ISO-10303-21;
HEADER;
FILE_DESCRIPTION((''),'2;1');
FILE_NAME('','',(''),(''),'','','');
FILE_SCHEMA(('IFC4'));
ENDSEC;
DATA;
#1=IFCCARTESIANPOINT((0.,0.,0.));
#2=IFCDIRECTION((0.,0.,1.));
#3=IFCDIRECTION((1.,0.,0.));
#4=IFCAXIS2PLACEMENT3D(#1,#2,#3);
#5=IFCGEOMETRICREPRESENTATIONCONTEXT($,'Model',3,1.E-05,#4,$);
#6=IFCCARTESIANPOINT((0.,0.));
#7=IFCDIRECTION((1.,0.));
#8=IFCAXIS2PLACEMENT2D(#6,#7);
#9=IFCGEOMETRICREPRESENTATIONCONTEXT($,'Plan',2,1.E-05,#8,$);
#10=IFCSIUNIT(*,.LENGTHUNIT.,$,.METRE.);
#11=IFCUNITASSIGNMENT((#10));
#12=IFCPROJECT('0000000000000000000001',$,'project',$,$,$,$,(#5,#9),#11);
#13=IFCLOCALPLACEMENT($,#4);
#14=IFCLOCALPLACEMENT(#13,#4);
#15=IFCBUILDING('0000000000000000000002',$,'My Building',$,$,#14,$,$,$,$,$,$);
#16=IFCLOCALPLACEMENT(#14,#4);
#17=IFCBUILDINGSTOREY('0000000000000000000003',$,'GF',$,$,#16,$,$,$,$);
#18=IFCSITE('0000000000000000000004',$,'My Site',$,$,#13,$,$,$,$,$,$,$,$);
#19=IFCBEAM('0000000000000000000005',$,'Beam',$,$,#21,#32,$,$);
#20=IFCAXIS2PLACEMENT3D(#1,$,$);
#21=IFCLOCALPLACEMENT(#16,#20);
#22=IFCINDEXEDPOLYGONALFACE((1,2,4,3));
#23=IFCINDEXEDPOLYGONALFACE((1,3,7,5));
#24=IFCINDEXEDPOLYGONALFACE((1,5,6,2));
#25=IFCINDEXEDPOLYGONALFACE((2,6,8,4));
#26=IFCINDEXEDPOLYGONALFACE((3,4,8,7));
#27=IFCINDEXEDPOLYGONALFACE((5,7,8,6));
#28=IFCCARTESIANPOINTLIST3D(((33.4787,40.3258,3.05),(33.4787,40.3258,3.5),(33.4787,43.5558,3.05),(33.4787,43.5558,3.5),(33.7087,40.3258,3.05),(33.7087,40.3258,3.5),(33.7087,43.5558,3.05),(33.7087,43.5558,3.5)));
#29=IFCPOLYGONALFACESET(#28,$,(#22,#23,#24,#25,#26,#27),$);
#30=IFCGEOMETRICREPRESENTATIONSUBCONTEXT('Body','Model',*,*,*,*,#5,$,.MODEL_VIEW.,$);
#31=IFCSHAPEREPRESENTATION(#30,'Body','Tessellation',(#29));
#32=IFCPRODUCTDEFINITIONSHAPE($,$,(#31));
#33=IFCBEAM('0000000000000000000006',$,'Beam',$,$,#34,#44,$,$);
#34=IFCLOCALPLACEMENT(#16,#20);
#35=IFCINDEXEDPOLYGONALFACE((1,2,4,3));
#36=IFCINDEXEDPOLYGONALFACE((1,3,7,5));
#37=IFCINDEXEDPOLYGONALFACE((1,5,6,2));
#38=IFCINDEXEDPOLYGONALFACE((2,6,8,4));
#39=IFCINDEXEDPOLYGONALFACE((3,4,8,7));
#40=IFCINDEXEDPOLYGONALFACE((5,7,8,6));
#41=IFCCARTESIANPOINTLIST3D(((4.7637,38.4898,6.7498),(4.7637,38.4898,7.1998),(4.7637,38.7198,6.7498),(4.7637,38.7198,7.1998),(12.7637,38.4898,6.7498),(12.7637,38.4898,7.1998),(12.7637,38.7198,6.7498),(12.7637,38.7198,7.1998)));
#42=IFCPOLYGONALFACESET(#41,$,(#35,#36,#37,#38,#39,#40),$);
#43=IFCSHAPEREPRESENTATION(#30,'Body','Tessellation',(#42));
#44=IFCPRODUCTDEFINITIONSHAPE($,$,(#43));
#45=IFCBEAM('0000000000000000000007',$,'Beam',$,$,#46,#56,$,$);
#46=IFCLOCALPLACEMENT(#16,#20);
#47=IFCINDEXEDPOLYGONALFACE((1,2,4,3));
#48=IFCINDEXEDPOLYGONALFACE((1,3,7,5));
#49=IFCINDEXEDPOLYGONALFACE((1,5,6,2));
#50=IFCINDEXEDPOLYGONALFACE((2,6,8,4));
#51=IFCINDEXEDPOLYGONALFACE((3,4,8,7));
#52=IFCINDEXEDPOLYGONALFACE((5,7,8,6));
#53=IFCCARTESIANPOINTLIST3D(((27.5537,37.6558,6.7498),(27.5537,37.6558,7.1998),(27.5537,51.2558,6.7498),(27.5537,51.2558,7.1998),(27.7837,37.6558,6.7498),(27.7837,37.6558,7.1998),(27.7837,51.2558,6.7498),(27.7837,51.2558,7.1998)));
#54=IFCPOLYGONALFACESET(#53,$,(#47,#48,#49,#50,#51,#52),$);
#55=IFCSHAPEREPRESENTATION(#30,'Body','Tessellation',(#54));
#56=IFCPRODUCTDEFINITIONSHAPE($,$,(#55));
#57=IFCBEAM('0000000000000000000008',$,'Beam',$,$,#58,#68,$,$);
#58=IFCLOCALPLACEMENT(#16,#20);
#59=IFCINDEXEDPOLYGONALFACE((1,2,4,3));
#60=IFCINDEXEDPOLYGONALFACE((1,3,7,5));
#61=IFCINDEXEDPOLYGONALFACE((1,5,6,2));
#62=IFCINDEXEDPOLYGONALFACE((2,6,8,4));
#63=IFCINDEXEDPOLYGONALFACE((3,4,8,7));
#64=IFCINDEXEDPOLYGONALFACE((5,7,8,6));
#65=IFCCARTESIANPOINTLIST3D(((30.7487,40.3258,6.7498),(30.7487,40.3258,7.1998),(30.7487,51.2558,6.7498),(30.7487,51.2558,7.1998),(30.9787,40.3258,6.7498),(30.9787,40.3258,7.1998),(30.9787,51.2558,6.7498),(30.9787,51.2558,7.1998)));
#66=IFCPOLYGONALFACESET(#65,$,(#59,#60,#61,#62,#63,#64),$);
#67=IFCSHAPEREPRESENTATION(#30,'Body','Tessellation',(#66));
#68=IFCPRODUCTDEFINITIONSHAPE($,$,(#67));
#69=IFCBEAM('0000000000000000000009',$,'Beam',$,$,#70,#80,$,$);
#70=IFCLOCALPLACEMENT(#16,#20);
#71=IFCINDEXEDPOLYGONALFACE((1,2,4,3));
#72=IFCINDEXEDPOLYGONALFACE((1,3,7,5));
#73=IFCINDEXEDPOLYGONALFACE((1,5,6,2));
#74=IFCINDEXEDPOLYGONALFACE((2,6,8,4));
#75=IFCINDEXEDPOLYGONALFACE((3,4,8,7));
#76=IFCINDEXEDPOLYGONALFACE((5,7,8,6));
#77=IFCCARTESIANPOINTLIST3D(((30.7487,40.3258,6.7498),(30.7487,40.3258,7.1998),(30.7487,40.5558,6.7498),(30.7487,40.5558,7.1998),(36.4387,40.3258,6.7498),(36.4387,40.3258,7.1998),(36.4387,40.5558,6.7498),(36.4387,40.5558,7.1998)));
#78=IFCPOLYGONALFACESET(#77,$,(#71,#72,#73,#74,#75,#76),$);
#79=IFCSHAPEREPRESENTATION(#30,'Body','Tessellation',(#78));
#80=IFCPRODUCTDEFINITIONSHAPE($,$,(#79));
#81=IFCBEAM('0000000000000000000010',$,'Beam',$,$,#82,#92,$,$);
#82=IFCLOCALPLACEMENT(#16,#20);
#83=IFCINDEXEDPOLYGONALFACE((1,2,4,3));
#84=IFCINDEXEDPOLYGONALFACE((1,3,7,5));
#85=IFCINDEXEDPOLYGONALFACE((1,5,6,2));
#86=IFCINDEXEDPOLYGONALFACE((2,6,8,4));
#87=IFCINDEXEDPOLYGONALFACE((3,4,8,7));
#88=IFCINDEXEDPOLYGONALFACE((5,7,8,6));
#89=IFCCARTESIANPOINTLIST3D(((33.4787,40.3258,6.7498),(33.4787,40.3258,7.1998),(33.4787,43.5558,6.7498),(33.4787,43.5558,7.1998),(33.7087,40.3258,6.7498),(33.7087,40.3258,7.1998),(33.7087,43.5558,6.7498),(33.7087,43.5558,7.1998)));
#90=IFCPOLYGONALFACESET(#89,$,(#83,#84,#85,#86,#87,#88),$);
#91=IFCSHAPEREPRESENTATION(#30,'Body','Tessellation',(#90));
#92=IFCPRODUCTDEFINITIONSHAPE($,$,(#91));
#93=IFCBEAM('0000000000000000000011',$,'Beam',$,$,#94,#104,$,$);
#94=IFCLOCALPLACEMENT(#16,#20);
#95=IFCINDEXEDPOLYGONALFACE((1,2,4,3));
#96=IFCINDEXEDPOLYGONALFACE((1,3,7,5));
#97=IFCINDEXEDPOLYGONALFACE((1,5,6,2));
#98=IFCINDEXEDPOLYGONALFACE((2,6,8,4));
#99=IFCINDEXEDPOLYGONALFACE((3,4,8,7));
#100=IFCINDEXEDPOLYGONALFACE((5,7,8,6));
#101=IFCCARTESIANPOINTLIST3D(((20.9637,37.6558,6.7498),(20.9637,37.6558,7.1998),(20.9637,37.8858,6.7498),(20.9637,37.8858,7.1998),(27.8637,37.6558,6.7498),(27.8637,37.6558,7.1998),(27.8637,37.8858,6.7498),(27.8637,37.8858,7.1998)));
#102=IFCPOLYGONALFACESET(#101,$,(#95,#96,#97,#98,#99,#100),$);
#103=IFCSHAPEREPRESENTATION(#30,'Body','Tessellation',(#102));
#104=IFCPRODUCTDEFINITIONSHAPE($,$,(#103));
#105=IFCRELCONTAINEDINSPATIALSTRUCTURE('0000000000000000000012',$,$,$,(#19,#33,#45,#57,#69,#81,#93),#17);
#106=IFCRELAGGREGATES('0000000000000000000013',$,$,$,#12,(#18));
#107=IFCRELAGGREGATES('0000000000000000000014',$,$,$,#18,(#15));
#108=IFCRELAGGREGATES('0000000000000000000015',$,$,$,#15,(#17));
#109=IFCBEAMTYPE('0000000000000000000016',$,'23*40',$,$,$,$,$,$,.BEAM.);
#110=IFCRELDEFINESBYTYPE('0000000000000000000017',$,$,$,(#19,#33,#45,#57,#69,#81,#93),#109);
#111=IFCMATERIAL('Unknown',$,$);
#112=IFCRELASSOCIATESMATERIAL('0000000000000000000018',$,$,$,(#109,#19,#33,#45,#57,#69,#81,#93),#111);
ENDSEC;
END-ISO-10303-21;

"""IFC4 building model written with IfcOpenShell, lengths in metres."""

from ifc_helpers import new_model, si_unit, frame, origin_with_axes, origin_2d_with_axis, place, context, subcontext, project, spatial, rectangle, extrude, material, material_profile, profile_set, profile_usage, type_object, element, save


model = new_model("IFC4")

# Units and contexts
model_context = context("Model", 3, precision=1e-05, world=origin_with_axes())
plan_context = context("Plan", 2, precision=1e-05, world=origin_2d_with_axis())
body_context = subcontext(model_context, "Body", "Model", "MODEL_VIEW")
ifc_project = project(units=[si_unit("LENGTHUNIT", "METRE")], contexts=[model_context, plan_context])

# Site, building, storey
site_placement = place(None, origin_with_axes())
site = spatial("IfcSite", under=ifc_project, at=site_placement, Name="My Site")
building_placement = place(site_placement, origin_with_axes())
building = spatial("IfcBuilding", under=site, at=building_placement, Name="My Building")
storey_placement = place(building_placement, origin_with_axes())
storey = spatial("IfcBuildingStorey", under=building, at=storey_placement, Name="GF")

# Shared definitions
ifc_material = material(Name="Unknown")

# Beams
ifc_material_profile_1 = material_profile(ifc_material, rectangle(XDim=0.23, YDim=0.45))
ifc_profile_set_1 = profile_set([ifc_material_profile_1])
beam_type = type_object("IfcBeamType", Name="23*40", PredefinedType="BEAM", material=ifc_profile_set_1)
ifc_profile_usage_1 = profile_usage(ifc_profile_set_1, cardinal=5)
beam_1_placement = place(storey_placement, frame((33.5937, 40.3258, 3.275), z_axis=(0.0, 1.0, 0.0), x_axis=(-1.0, 0.0, 0.0)))
element("IfcBeam", 1, at=beam_1_placement, inside=storey, type_object=beam_type, material=ifc_profile_usage_1, Name="Beam", context=body_context, shape_type="SweptSolid", body=[
    extrude(rectangle(XDim=0.23, YDim=0.45), origin_with_axes(), (0.0, 0.0, 1.0), 3.23),
])
ifc_profile_usage_2 = profile_usage(ifc_profile_set_1, cardinal=5)
beam_2_placement = place(storey_placement, frame((4.7637, 38.6048, 6.9748), z_axis=(1.0, 0.0, 0.0), x_axis=(0.0, 1.0, 0.0)))
element("IfcBeam", 2, at=beam_2_placement, inside=storey, type_object=beam_type, material=ifc_profile_usage_2, Name="Beam", context=body_context, shape_type="SweptSolid", body=[
    extrude(rectangle(XDim=0.23, YDim=0.45), origin_with_axes(), (0.0, 0.0, 1.0), 8.0),
])
ifc_profile_usage_3 = profile_usage(ifc_profile_set_1, cardinal=5)
beam_3_placement = place(storey_placement, frame((27.6687, 37.6558, 6.9748), z_axis=(0.0, 1.0, 0.0), x_axis=(-1.0, 0.0, 0.0)))
element("IfcBeam", 3, at=beam_3_placement, inside=storey, type_object=beam_type, material=ifc_profile_usage_3, Name="Beam", context=body_context, shape_type="SweptSolid", body=[
    extrude(rectangle(XDim=0.23, YDim=0.45), origin_with_axes(), (0.0, 0.0, 1.0), 13.6),
])
ifc_profile_usage_4 = profile_usage(ifc_profile_set_1, cardinal=5)
beam_4_placement = place(storey_placement, frame((30.8637, 40.3258, 6.9748), z_axis=(0.0, 1.0, 0.0), x_axis=(-1.0, 0.0, 0.0)))
element("IfcBeam", 4, at=beam_4_placement, inside=storey, type_object=beam_type, material=ifc_profile_usage_4, Name="Beam", context=body_context, shape_type="SweptSolid", body=[
    extrude(rectangle(XDim=0.23, YDim=0.45), origin_with_axes(), (0.0, 0.0, 1.0), 10.93),
])
ifc_profile_usage_5 = profile_usage(ifc_profile_set_1, cardinal=5)
beam_5_placement = place(storey_placement, frame((30.7487, 40.4408, 6.9748), z_axis=(1.0, 0.0, 0.0), x_axis=(0.0, 1.0, 0.0)))
element("IfcBeam", 5, at=beam_5_placement, inside=storey, type_object=beam_type, material=ifc_profile_usage_5, Name="Beam", context=body_context, shape_type="SweptSolid", body=[
    extrude(rectangle(XDim=0.23, YDim=0.45), origin_with_axes(), (0.0, 0.0, 1.0), 5.69),
])
ifc_profile_usage_6 = profile_usage(ifc_profile_set_1, cardinal=5)
beam_6_placement = place(storey_placement, frame((33.5937, 40.3258, 6.9748), z_axis=(0.0, 1.0, 0.0), x_axis=(-1.0, 0.0, 0.0)))
element("IfcBeam", 6, at=beam_6_placement, inside=storey, type_object=beam_type, material=ifc_profile_usage_6, Name="Beam", context=body_context, shape_type="SweptSolid", body=[
    extrude(rectangle(XDim=0.23, YDim=0.45), origin_with_axes(), (0.0, 0.0, 1.0), 3.23),
])
ifc_profile_usage_7 = profile_usage(ifc_profile_set_1, cardinal=5)
beam_7_placement = place(storey_placement, frame((20.9637, 37.7708, 6.9748), z_axis=(1.0, 0.0, 0.0), x_axis=(0.0, 1.0, 0.0)))
element("IfcBeam", 7, at=beam_7_placement, inside=storey, type_object=beam_type, material=ifc_profile_usage_7, Name="Beam", context=body_context, shape_type="SweptSolid", body=[
    extrude(rectangle(XDim=0.23, YDim=0.45), origin_with_axes(), (0.0, 0.0, 1.0), 6.9),
])

save(model, "model.ifc")
